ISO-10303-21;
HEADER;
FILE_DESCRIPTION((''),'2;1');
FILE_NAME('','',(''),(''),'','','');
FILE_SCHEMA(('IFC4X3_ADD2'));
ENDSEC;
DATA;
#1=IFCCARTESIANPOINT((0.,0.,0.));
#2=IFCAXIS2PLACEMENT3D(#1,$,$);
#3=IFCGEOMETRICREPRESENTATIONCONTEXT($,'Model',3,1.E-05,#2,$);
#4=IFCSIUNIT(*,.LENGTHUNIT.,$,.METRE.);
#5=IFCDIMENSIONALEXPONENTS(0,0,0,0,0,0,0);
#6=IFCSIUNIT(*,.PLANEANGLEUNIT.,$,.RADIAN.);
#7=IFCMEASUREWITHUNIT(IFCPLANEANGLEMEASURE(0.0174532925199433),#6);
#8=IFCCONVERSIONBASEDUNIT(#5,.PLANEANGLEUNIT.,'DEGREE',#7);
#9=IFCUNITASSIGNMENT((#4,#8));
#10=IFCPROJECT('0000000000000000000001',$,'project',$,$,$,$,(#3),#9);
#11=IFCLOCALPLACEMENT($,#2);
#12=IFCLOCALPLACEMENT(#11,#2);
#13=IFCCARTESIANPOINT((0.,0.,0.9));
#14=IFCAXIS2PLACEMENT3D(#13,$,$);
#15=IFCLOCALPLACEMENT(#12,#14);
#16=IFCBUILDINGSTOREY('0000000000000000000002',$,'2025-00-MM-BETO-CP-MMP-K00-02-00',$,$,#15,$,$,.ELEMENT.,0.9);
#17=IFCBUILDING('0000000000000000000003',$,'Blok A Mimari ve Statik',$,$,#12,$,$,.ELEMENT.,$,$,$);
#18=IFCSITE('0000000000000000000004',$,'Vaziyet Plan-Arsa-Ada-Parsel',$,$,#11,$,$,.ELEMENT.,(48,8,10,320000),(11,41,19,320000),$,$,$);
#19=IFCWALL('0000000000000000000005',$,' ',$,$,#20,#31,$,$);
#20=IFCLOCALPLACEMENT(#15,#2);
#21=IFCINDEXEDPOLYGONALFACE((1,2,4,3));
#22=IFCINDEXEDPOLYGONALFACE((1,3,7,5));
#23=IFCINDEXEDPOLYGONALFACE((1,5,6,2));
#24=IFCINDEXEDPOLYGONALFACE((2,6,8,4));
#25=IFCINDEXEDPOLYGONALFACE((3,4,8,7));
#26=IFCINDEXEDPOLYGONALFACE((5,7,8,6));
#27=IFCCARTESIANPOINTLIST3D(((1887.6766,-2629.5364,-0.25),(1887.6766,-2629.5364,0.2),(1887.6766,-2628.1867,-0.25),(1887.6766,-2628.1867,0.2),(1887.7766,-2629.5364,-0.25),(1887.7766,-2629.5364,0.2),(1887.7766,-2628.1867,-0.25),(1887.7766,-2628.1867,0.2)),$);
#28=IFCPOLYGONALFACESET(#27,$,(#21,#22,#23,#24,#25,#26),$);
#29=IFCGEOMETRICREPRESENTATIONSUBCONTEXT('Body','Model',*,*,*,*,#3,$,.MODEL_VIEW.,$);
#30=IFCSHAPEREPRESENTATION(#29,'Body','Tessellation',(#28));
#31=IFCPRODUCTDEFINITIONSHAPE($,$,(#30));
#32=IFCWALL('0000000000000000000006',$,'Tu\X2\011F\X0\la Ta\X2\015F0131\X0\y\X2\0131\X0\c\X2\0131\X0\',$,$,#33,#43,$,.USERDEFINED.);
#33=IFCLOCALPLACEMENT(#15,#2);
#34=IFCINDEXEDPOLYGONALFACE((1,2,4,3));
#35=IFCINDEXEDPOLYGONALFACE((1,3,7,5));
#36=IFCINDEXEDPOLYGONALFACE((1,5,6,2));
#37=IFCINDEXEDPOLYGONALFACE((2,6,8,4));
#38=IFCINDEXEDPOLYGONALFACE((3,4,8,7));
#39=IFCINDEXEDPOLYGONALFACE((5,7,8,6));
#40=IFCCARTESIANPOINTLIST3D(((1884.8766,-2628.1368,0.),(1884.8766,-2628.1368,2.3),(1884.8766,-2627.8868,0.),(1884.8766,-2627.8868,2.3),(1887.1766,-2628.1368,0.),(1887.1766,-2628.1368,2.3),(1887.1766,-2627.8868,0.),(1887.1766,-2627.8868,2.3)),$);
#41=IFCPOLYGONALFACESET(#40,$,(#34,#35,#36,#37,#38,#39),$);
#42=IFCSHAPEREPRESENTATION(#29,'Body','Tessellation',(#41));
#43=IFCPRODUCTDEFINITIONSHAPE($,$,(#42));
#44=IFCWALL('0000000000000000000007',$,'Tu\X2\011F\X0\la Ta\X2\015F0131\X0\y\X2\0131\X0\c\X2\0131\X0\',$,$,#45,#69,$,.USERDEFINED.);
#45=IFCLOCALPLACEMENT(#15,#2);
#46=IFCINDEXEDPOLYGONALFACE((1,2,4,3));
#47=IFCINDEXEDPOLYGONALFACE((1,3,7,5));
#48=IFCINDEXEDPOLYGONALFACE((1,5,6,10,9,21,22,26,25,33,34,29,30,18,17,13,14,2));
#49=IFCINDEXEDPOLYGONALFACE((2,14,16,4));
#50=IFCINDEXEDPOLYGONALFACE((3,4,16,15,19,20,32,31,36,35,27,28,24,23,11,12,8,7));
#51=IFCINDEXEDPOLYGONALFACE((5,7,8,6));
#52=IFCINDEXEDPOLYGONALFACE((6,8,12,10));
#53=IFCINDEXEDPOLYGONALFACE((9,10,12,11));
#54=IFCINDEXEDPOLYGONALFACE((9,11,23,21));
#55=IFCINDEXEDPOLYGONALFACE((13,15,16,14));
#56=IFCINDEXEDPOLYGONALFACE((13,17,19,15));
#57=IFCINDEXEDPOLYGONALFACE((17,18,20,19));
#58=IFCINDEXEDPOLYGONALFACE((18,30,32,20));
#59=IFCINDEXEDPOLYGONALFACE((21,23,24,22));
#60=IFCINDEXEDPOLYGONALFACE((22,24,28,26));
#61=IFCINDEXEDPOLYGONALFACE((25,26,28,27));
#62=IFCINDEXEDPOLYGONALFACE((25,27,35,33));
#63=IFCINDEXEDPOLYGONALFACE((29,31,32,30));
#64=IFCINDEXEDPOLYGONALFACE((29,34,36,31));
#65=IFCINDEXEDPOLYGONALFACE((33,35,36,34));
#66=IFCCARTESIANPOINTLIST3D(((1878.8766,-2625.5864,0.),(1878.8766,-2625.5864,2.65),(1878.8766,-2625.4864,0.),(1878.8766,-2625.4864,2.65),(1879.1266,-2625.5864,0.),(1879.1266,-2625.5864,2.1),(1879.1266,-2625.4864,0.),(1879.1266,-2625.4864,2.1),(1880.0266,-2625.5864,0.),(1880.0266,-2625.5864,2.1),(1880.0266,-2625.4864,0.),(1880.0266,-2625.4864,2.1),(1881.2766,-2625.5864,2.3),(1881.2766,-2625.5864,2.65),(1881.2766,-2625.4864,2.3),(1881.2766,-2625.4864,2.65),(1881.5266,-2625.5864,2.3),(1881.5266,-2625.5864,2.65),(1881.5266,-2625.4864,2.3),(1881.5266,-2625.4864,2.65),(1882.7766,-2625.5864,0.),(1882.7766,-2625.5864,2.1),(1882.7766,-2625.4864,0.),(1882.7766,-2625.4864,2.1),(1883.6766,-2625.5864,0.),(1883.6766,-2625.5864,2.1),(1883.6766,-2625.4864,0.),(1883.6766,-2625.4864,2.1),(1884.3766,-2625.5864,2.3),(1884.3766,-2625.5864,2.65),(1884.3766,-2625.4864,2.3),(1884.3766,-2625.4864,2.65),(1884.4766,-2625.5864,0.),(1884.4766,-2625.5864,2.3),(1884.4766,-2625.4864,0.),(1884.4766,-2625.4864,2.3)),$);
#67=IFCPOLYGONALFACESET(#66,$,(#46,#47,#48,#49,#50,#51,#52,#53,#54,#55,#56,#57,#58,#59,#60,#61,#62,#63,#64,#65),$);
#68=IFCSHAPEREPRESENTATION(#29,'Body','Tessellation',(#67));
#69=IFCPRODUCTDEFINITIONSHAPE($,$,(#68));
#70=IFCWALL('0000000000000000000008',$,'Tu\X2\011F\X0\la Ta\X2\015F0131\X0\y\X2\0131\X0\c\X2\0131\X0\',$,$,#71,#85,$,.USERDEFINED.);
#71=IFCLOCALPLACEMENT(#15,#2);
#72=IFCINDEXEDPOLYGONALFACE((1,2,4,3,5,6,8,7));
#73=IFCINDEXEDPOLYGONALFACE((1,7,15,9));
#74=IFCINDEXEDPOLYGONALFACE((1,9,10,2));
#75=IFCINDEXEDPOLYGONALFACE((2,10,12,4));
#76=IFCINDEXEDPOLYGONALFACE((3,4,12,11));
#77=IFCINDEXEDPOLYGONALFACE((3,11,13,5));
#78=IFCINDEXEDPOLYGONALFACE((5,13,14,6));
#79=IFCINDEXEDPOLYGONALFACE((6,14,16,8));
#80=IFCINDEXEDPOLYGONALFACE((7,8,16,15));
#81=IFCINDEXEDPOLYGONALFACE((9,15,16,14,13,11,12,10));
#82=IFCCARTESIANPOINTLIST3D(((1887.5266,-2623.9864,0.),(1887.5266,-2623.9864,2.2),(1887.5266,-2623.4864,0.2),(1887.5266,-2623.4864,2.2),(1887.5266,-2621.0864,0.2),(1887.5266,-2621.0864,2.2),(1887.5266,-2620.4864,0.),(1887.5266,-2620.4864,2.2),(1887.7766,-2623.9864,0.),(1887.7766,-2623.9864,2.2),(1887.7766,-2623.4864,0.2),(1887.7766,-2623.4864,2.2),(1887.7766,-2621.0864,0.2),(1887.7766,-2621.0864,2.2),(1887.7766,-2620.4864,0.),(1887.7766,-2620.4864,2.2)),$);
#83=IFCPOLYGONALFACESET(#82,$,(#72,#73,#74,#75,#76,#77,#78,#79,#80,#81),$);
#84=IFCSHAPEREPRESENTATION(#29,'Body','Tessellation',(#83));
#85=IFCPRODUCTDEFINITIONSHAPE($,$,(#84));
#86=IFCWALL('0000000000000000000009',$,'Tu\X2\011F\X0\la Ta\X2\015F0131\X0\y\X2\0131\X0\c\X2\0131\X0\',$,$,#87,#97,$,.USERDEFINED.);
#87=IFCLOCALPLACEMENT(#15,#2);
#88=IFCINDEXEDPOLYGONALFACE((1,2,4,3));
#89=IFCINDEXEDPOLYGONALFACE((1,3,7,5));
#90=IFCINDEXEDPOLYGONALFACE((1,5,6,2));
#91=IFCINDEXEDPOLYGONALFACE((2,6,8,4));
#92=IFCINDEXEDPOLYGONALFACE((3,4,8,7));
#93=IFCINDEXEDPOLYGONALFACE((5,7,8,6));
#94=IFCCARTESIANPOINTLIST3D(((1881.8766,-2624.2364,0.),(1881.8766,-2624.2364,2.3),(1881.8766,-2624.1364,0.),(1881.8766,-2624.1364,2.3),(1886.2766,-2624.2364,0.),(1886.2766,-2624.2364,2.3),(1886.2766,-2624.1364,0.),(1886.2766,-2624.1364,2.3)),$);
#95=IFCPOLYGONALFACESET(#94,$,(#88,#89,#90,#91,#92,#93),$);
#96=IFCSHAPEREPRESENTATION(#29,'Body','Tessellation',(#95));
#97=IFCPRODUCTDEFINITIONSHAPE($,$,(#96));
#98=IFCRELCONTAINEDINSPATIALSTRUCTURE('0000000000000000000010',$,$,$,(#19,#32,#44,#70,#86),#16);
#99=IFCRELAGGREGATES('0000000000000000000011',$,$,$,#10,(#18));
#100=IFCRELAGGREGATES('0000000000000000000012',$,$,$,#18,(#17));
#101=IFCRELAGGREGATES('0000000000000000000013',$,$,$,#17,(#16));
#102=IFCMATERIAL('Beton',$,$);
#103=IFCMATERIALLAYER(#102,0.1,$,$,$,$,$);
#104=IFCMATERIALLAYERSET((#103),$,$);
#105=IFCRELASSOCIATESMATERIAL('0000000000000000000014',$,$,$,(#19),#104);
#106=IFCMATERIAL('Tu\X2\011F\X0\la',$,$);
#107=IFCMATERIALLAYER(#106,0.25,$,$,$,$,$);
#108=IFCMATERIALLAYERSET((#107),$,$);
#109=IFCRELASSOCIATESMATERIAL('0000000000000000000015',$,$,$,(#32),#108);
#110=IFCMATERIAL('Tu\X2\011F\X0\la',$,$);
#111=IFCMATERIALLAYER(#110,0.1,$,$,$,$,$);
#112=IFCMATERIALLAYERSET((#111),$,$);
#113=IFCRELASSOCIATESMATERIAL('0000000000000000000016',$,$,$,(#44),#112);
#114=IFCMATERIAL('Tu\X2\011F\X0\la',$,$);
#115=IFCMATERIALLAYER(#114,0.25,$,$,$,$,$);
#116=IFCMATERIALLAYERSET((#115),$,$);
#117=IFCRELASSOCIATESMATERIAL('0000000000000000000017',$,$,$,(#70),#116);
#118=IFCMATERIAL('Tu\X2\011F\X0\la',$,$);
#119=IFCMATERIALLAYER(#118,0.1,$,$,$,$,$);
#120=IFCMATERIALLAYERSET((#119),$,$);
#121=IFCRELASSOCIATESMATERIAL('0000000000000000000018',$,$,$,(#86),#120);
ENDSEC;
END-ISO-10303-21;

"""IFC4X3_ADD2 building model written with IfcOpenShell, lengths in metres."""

from ifc_helpers import new_model, entity, si_unit, converted_unit, frame, frame_2d, origin, origin_with_axes, place, context, subcontext, project, spatial, polyline, rectangle, outline, extrude, clip, bounded_halfspace, material, layer, layer_set, layer_usage, element, save


model = new_model("IFC4X3_ADD2")

# Units and contexts
model_context = context("Model", 3, precision=1e-05, world=origin())
body_context = subcontext(model_context, "Body", "Model", "MODEL_VIEW")
ifc_project = project(units=[si_unit("LENGTHUNIT", "METRE"), converted_unit("PLANEANGLEUNIT", "DEGREE", entity("IfcPlaneAngleMeasure", 0.0174532925199433), si_unit("PLANEANGLEUNIT", "RADIAN"), dimensions=[0, 0, 0, 0, 0, 0, 0])], contexts=[model_context])

# Site, building, storey
site_placement = place(None, origin())
site = spatial("IfcSite", under=ifc_project, at=site_placement, Name="Vaziyet Plan-Arsa-Ada-Parsel", CompositionType="ELEMENT", RefLatitude=(48, 8, 10, 320000), RefLongitude=(11, 41, 19, 320000))
building_placement = place(site_placement, origin())
building = spatial("IfcBuilding", under=site, at=building_placement, Name="Blok A Mimari ve Statik", CompositionType="ELEMENT")
storey_placement = place(building_placement, frame((0.0, 0.0, 0.9)))
storey = spatial("IfcBuildingStorey", under=building, at=storey_placement, Name="2025-00-MM-BETO-CP-MMP-K00-02-00", CompositionType="ELEMENT", Elevation=0.9)

# Walls
ifc_material_1 = material(Name="Beton")
ifc_layer_1 = layer(ifc_material_1, 0.1)
ifc_layer_set_1 = layer_set([ifc_layer_1])
ifc_layer_usage_1 = layer_usage(ifc_layer_set_1, "AXIS2", "POSITIVE", 0.0)
wall_1_placement = place(storey_placement, frame((1887.7766, -2629.5364, -0.25), z_axis=(0.0, 0.0, 1.0), x_axis=(0.0, 1.0, 0.0)))
element("IfcWall", 1, at=wall_1_placement, inside=storey, material=ifc_layer_usage_1, Name=" ", context=body_context, shape_type="SweptSolid", body=[
    extrude(rectangle(XDim=1.3497, YDim=0.1, at=frame_2d((0.6748, 0.05), x_axis=(1.0, 0.0))), origin_with_axes(), (0.0, 0.0, 1.0), 0.45),
])
ifc_material_2 = material(Name="Tuğla")
ifc_layer_2 = layer(ifc_material_2, 0.25)
ifc_layer_set_2 = layer_set([ifc_layer_2])
ifc_layer_usage_2 = layer_usage(ifc_layer_set_2, "AXIS2", "POSITIVE", 0.0)
wall_2_placement = place(storey_placement, frame((1887.1766, -2627.8868, 0.0), z_axis=(0.0, 0.0, 1.0), x_axis=(-1.0, 0.0, 0.0)))
element("IfcWall", 2, at=wall_2_placement, inside=storey, material=ifc_layer_usage_2, Name="Tuğla Taşıyıcı", PredefinedType="USERDEFINED", context=body_context, shape_type="SweptSolid", body=[
    extrude(rectangle(XDim=2.3, YDim=0.25, at=frame_2d((1.15, 0.125), x_axis=(1.0, 0.0))), origin_with_axes(), (0.0, 0.0, 1.0), 2.3),
])

# Wall, openings
ifc_material_3 = material(Name="Tuğla")
ifc_layer_3 = layer(ifc_material_3, 0.1)
ifc_layer_set_3 = layer_set([ifc_layer_3])
ifc_layer_usage_3 = layer_usage(ifc_layer_set_3, "AXIS2", "POSITIVE", 0.0)
wall_3_placement = place(storey_placement, frame((1884.4766, -2625.4864, 0.0), z_axis=(0.0, 0.0, 1.0), x_axis=(-1.0, 0.0, 0.0)))
wall_3 = element("IfcWall", 3, at=wall_3_placement, inside=storey, material=ifc_layer_usage_3, Name="Tuğla Taşıyıcı", PredefinedType="USERDEFINED", context=body_context, shape_type="Clipping", body=[
    clip(clip(extrude(rectangle(XDim=5.6, YDim=0.1, at=frame_2d((2.8, 0.05), x_axis=(1.0, 0.0))), origin_with_axes(), (0.0, 0.0, 1.0), 2.65), bounded_halfspace(frame((3.075, 0.05, 2.3), z_axis=(0.0, 0.0, -1.0), x_axis=(0.0, -1.0, 0.0)), True, origin_with_axes(), polyline([(2.95, 0.1), (2.95, 0.0), (3.2, 0.0), (3.2, 0.1), (2.95, 0.1)]))), bounded_halfspace(frame((0.05, 0.05, 2.3), z_axis=(0.0, 0.0, -1.0), x_axis=(0.0, -1.0, 0.0)), True, origin_with_axes(), polyline([(0.0, 0.1), (0.0, 0.0), (0.1, 0.0), (0.1, 0.1), (0.0, 0.1)]))),
])
opening_1_placement = place(wall_3_placement, frame((0.8, 0.0, 0.0), z_axis=(0.0, 1.0, 0.0), x_axis=(0.0, 0.0, 1.0)))
element("IfcOpeningElement", 4, at=opening_1_placement, cuts=wall_3, PredefinedType="OPENING", context=body_context, shape_type="SweptSolid", body=[
    extrude(outline(polyline([(2.1, 0.9), (2.1, 0.0), (0.0, 0.0), (0.0, 0.9), (2.1, 0.9)])), origin_with_axes(), (0.0, 0.0, 1.0), 0.1),
])
opening_2_placement = place(wall_3_placement, frame((4.45, 0.0, 0.0), z_axis=(0.0, 1.0, 0.0), x_axis=(0.0, 0.0, 1.0)))
element("IfcOpeningElement", 5, at=opening_2_placement, cuts=wall_3, PredefinedType="OPENING", context=body_context, shape_type="SweptSolid", body=[
    extrude(outline(polyline([(2.1, 0.9), (2.1, 0.0), (0.0, 0.0), (0.0, 0.9), (2.1, 0.9)])), origin_with_axes(), (0.0, 0.0, 1.0), 0.1),
])

# Wall, opening
ifc_material_4 = material(Name="Tuğla")
ifc_layer_4 = layer(ifc_material_4, 0.25)
ifc_layer_set_4 = layer_set([ifc_layer_4])
ifc_layer_usage_4 = layer_usage(ifc_layer_set_4, "AXIS2", "POSITIVE", 0.0)
wall_4_placement = place(storey_placement, frame((1887.7766, -2623.9864, 0.0), z_axis=(0.0, 0.0, 1.0), x_axis=(0.0, 1.0, 0.0)))
wall_4 = element("IfcWall", 6, at=wall_4_placement, inside=storey, material=ifc_layer_usage_4, Name="Tuğla Taşıyıcı", PredefinedType="USERDEFINED", context=body_context, shape_type="SweptSolid", body=[
    extrude(rectangle(XDim=3.5, YDim=0.25, at=frame_2d((1.75, 0.125), x_axis=(1.0, 0.0))), origin_with_axes(), (0.0, 0.0, 1.0), 2.2),
])
opening_3_placement = place(wall_4_placement, frame((0.5, 0.0, 0.2), z_axis=(0.0, 1.0, 0.0), x_axis=(0.0, 0.0, 1.0)))
element("IfcOpeningElement", 7, at=opening_3_placement, cuts=wall_4, PredefinedType="OPENING", context=body_context, shape_type="SweptSolid", body=[
    extrude(outline(polyline([(2.1, 2.4), (2.1, 0.0), (0.0, 0.0), (0.0, 2.4), (2.1, 2.4)])), origin_with_axes(), (0.0, 0.0, 1.0), 0.25),
])

# Wall
ifc_material_5 = material(Name="Tuğla")
ifc_layer_5 = layer(ifc_material_5, 0.1)
ifc_layer_set_5 = layer_set([ifc_layer_5])
ifc_layer_usage_5 = layer_usage(ifc_layer_set_5, "AXIS2", "POSITIVE", 0.0)
wall_5_placement = place(storey_placement, frame((1881.8766, -2624.2364, 0.0)))
element("IfcWall", 8, at=wall_5_placement, inside=storey, material=ifc_layer_usage_5, Name="Tuğla Taşıyıcı", PredefinedType="USERDEFINED", context=body_context, shape_type="SweptSolid", body=[
    extrude(rectangle(XDim=4.4, YDim=0.1, at=frame_2d((2.2, 0.05), x_axis=(1.0, 0.0))), origin_with_axes(), (0.0, 0.0, 1.0), 2.3),
])

save(model, "model.ifc")
